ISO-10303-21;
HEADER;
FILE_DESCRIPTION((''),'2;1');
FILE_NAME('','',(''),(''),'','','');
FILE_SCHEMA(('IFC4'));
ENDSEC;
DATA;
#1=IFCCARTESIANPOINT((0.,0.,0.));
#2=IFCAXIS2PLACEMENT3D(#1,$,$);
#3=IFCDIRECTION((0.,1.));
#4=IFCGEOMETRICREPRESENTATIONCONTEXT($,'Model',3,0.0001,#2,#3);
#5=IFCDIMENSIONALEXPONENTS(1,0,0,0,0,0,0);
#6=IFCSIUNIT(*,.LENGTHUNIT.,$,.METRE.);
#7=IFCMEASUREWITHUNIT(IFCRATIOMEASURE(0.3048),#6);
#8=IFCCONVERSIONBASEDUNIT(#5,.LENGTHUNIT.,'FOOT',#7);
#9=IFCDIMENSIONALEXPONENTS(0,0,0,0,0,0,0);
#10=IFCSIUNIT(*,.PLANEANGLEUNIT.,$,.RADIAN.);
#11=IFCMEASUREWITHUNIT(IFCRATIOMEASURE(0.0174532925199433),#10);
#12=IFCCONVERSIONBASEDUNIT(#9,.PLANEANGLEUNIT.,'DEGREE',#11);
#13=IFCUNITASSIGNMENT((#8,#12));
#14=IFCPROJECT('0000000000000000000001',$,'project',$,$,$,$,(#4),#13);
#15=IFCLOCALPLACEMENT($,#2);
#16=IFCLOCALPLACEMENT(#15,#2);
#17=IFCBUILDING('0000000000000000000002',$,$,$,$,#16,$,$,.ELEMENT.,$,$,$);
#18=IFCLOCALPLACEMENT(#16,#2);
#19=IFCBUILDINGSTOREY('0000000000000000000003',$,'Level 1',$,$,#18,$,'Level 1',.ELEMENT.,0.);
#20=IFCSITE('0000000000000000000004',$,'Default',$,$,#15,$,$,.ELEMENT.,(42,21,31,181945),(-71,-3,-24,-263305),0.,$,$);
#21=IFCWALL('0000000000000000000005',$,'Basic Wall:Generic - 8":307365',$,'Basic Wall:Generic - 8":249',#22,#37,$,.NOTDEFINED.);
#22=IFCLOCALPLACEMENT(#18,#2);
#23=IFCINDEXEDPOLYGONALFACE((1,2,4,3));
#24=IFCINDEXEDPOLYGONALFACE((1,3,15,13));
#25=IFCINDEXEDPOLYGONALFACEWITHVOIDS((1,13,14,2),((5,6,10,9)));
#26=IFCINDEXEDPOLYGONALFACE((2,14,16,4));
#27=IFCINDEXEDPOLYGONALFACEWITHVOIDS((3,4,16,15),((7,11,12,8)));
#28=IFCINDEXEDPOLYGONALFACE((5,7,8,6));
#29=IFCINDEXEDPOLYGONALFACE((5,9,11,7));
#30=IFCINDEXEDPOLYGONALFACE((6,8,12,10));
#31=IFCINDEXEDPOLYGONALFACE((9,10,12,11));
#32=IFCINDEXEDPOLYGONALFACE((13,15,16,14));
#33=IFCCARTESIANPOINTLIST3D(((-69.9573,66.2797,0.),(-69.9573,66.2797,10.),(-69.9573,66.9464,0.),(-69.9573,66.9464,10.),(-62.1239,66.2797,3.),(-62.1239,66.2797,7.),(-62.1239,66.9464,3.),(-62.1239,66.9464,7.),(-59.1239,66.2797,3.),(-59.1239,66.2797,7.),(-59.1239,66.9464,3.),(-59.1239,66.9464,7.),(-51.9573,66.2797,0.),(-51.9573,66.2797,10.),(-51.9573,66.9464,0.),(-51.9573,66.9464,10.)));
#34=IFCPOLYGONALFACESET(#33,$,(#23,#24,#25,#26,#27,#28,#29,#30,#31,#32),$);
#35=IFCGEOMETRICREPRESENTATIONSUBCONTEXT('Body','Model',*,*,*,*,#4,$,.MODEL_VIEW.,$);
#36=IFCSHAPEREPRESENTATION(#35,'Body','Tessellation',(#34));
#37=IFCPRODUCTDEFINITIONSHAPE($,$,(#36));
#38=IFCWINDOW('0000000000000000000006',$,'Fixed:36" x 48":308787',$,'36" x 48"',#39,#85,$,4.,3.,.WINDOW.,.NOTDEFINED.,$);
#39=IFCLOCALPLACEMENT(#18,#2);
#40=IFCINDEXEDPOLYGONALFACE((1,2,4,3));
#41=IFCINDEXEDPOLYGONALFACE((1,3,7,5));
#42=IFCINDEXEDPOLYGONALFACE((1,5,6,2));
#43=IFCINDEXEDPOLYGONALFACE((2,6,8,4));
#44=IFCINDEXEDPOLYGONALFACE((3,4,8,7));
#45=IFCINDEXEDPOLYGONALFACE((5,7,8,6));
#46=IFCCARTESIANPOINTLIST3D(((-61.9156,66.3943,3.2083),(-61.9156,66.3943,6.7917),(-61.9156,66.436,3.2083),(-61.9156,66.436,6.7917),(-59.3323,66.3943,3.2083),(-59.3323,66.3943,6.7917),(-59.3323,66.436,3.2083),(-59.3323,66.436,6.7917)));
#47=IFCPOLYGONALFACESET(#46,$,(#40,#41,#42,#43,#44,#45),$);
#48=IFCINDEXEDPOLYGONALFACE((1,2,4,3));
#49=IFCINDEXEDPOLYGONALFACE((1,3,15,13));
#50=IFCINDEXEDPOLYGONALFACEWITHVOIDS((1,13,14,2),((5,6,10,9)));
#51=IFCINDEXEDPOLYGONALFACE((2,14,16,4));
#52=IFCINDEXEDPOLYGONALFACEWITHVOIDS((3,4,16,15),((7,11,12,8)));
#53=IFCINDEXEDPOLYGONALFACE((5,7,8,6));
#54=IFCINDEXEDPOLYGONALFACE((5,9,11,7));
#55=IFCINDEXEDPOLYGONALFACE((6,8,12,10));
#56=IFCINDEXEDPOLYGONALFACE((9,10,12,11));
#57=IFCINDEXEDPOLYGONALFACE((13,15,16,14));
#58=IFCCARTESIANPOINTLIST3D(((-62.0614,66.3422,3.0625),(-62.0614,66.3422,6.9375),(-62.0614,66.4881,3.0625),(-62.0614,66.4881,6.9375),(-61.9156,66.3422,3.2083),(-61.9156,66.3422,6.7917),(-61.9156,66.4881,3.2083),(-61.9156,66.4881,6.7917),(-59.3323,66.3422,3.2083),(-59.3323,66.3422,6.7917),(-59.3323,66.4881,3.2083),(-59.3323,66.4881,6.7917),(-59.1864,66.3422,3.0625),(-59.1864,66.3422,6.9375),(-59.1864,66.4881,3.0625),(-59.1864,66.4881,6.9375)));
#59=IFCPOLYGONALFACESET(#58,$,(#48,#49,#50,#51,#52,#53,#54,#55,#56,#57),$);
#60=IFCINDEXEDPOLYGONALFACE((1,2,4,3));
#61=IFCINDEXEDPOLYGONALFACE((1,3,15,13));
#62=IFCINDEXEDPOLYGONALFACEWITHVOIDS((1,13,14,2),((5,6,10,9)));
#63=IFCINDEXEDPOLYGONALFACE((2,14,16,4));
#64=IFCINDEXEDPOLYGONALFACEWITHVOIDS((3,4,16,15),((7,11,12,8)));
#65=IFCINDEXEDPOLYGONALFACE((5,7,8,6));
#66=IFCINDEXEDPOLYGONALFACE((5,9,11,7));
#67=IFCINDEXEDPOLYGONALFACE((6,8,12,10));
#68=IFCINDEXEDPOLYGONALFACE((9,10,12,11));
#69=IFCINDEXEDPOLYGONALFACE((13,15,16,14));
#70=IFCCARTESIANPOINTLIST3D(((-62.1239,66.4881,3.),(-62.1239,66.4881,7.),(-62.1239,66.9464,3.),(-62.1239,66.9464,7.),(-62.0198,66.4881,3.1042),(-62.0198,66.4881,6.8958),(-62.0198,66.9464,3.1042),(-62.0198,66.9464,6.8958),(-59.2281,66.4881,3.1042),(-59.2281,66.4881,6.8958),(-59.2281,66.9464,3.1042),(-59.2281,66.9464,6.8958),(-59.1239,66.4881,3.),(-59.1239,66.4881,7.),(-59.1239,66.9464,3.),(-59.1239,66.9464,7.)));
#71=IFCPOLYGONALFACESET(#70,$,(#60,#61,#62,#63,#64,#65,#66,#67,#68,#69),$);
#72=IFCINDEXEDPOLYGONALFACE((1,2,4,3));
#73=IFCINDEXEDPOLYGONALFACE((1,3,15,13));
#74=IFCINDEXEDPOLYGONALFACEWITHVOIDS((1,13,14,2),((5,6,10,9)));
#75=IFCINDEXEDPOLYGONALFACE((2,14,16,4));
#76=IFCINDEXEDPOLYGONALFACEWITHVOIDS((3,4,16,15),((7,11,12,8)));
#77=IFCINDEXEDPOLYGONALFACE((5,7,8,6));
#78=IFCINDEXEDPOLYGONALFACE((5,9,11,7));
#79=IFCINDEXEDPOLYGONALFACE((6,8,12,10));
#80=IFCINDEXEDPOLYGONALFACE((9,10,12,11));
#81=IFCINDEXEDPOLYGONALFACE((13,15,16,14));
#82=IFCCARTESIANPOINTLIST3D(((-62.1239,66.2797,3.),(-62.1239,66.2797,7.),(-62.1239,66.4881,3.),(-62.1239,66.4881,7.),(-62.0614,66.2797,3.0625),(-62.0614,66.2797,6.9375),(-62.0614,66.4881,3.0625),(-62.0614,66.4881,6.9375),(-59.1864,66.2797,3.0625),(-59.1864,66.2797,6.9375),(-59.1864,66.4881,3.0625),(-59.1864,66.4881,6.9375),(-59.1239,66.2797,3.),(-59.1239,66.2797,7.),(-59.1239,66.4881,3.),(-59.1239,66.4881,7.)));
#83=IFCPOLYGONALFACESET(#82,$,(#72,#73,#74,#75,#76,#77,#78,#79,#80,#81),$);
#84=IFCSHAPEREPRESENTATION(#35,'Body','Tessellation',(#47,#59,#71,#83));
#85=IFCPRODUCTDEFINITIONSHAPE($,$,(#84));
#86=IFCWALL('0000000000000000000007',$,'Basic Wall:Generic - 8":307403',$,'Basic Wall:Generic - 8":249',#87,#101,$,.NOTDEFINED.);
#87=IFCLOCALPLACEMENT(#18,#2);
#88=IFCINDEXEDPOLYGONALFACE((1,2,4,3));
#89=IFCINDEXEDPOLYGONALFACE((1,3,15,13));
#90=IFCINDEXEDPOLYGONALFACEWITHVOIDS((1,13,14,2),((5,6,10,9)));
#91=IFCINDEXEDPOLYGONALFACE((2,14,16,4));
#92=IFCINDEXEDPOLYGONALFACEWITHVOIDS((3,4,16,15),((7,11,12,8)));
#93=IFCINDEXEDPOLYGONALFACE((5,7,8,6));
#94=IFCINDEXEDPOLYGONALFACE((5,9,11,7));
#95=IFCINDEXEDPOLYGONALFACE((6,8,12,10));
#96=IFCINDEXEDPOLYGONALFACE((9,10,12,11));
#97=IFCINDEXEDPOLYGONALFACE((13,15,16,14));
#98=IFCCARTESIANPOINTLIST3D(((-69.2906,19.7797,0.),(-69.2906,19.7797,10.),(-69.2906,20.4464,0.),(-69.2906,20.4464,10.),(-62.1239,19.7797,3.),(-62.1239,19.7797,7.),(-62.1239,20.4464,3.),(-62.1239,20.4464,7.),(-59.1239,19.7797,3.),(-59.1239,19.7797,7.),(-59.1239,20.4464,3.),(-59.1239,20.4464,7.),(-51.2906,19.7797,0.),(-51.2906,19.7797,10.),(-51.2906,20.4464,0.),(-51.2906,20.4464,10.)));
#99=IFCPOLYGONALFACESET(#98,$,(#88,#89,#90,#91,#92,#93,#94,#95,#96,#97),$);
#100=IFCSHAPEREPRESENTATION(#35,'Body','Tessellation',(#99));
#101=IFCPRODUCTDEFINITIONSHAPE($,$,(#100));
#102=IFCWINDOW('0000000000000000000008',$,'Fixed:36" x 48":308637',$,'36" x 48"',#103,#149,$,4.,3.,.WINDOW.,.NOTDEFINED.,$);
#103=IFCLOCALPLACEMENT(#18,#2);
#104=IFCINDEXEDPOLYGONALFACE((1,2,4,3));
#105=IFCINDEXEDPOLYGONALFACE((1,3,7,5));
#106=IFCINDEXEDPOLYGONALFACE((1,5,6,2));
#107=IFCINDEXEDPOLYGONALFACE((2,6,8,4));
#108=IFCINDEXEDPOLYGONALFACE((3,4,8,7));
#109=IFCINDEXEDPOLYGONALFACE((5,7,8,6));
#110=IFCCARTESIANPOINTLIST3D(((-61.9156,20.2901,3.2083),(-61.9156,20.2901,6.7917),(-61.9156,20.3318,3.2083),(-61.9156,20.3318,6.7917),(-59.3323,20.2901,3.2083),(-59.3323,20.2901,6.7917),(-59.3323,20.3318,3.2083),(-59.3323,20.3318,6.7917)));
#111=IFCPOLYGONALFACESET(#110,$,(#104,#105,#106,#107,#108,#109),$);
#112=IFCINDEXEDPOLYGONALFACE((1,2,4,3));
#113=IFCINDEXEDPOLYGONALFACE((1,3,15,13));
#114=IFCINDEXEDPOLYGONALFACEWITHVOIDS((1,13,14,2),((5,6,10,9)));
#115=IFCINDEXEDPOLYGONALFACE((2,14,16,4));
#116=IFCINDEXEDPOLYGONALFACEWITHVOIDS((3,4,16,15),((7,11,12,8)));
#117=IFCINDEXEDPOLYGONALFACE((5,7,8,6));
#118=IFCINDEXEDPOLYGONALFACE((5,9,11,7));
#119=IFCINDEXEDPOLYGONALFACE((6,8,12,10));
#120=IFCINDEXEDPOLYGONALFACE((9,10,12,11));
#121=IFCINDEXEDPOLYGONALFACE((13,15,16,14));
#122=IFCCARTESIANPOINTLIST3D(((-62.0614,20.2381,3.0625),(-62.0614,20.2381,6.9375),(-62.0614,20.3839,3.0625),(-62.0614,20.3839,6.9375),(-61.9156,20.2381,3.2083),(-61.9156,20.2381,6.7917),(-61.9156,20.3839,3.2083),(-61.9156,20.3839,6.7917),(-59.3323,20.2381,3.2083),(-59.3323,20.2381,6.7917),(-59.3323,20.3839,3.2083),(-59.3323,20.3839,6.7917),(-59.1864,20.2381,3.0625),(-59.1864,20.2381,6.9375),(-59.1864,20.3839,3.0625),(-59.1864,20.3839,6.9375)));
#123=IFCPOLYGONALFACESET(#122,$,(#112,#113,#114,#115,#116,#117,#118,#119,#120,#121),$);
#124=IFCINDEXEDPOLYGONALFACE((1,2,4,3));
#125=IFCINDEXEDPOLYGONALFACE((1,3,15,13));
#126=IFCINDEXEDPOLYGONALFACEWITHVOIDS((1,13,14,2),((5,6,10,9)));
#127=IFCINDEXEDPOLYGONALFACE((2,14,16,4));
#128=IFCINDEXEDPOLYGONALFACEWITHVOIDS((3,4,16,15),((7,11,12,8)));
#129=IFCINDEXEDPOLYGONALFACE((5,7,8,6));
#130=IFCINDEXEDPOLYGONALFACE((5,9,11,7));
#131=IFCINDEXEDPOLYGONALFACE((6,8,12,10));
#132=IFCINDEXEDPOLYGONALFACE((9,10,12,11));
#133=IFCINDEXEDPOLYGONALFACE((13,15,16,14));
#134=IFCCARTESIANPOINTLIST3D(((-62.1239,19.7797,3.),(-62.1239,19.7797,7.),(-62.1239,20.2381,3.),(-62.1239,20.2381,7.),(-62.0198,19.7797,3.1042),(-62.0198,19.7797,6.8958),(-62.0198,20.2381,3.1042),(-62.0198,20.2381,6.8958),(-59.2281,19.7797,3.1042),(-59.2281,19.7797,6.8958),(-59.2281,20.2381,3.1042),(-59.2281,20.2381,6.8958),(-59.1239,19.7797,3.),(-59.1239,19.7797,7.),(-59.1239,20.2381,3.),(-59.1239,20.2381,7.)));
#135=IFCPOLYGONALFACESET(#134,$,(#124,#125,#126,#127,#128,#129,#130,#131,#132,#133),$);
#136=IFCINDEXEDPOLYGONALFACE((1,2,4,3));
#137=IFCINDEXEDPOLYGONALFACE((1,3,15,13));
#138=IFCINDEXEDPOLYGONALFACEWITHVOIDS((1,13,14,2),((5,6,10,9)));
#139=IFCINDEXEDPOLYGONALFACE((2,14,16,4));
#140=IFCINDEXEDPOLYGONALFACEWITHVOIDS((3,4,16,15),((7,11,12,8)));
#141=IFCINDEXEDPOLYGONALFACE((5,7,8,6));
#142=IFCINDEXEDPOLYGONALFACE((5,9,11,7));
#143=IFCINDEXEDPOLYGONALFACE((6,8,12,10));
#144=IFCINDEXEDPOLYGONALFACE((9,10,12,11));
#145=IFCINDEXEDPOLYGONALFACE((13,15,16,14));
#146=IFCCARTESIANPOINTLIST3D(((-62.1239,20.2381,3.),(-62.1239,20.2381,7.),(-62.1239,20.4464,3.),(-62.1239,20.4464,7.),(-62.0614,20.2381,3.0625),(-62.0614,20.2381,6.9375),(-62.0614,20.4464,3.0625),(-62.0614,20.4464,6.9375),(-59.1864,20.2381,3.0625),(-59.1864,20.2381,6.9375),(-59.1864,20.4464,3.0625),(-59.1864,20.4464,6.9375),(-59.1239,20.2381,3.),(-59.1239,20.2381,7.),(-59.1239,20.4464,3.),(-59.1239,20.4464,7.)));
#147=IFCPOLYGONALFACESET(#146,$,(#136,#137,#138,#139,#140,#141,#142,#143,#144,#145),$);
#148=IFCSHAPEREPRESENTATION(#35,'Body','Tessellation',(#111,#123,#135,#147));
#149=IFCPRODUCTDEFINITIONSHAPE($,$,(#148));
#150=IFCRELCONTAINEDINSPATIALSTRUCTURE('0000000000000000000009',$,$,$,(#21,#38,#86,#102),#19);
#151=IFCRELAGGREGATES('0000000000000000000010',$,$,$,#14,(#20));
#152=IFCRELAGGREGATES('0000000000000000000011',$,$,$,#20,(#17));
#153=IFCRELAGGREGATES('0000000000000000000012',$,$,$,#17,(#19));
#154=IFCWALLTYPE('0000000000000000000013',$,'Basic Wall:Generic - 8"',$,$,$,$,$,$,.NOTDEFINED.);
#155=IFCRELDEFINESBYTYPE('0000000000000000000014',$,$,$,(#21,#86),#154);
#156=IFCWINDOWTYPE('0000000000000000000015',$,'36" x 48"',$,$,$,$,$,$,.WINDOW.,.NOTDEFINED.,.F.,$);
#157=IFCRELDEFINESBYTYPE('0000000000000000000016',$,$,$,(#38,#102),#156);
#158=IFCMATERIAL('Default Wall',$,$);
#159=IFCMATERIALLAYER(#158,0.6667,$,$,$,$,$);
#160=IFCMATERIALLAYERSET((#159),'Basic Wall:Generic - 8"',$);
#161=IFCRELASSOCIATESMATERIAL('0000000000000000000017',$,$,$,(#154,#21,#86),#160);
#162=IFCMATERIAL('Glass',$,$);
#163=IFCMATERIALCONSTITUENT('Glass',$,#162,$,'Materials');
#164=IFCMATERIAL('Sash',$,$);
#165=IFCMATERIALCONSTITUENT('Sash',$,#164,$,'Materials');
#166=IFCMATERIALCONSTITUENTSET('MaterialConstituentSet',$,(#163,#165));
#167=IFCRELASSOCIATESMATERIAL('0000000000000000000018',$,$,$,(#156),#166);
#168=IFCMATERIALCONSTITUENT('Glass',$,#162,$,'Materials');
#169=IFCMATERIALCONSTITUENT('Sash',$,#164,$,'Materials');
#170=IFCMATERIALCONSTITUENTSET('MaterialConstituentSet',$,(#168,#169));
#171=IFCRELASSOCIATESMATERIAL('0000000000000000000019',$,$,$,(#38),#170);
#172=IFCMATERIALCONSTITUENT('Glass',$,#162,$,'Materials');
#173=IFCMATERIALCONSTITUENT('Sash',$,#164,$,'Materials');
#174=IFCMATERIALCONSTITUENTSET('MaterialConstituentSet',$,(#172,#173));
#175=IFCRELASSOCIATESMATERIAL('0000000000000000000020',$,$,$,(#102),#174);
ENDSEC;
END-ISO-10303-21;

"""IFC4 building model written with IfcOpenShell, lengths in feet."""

from ifc_helpers import new_model, entity, si_unit, converted_unit, direction, frame, frame_2d, origin, place, context, subcontext, project, spatial, polyline, rectangle, outline, extrude, source, transform, mapped, material, layer, layer_set, layer_usage, constituent, constituent_set, type_object, type_shapes, element, fill, save


model = new_model("IFC4")

# Units and contexts
model_context = context("Model", 3, precision=0.0001, world=origin(), true_north=direction((0.0, 1.0)))
body_context = subcontext(model_context, "Body", "Model", "MODEL_VIEW")
ifc_project = project(units=[converted_unit("LENGTHUNIT", "FOOT", entity("IfcRatioMeasure", 0.3048), si_unit("LENGTHUNIT", "METRE"), dimensions=[1, 0, 0, 0, 0, 0, 0]), converted_unit("PLANEANGLEUNIT", "DEGREE", entity("IfcRatioMeasure", 0.0174532925199433), si_unit("PLANEANGLEUNIT", "RADIAN"), dimensions=[0, 0, 0, 0, 0, 0, 0])], contexts=[model_context])

# Site, building, storey
site_placement = place(None, origin())
site = spatial("IfcSite", under=ifc_project, at=site_placement, Name="Default", CompositionType="ELEMENT", RefLatitude=(42, 21, 31, 181945), RefLongitude=(-71, -3, -24, -263305), RefElevation=0.0)
building_placement = place(site_placement, origin())
building = spatial("IfcBuilding", under=site, at=building_placement, CompositionType="ELEMENT")
storey_placement = place(building_placement, origin())
storey = spatial("IfcBuildingStorey", under=building, at=storey_placement, Name="Level 1", LongName="Level 1", CompositionType="ELEMENT", Elevation=0.0)

# Wall, opening, window
ifc_material_1 = material(Name="Default Wall")
ifc_layer = layer(ifc_material_1, 0.6667)
ifc_layer_set = layer_set([ifc_layer], Name="Basic Wall:Generic - 8\"")
ifc_layer_usage_1 = layer_usage(ifc_layer_set, "AXIS2", "NEGATIVE", 0.3333)
wall_type = type_object("IfcWallType", Name="Basic Wall:Generic - 8\"", PredefinedType="NOTDEFINED", material=ifc_layer_set)
wall_1_placement = place(storey_placement, frame((-69.9573, 66.6131, 0.0)))
wall_1 = element("IfcWall", 1, at=wall_1_placement, inside=storey, type_object=wall_type, material=ifc_layer_usage_1, Name="Basic Wall:Generic - 8\":307365", ObjectType="Basic Wall:Generic - 8\":249", PredefinedType="NOTDEFINED", context=body_context, shape_type="SweptSolid", body=[
    extrude(rectangle(XDim=18.0, YDim=0.6667, at=frame_2d((9.0, 0.0), x_axis=(-1.0, 0.0))), origin(), (0.0, 0.0, 1.0), 10.0),
])
opening_1_placement = place(wall_1_placement, frame((10.8333, 0.3333, 3.0)))
opening_1 = element("IfcOpeningElement", 2, at=opening_1_placement, cuts=wall_1, ObjectType="Opening", PredefinedType="OPENING", context=body_context, shape_type="SweptSolid", body=[
    extrude(rectangle(XDim=4.0, YDim=3.0, at=frame_2d((2.0, 1.5), x_axis=(-1.0, 0.0))), frame((0.0, 0.0, 0.0), z_axis=(0.0, -1.0, 0.0), x_axis=(0.0, 0.0, 1.0)), (0.0, 0.0, 1.0), 0.6667),
])
ifc_material_2 = material(Name="Glass")
ifc_constituent_1 = constituent(ifc_material_2, Name="Glass", Category="Materials")
ifc_material_3 = material(Name="Sash")
ifc_constituent_2 = constituent(ifc_material_3, Name="Sash", Category="Materials")
ifc_constituent_set_1 = constituent_set(constituents=[ifc_constituent_1, ifc_constituent_2], Name="MaterialConstituentSet")
ifc_constituent_3 = constituent(ifc_material_2, Name="Glass", Category="Materials")
ifc_constituent_4 = constituent(ifc_material_3, Name="Sash", Category="Materials")
ifc_constituent_set_2 = constituent_set(constituents=[ifc_constituent_3, ifc_constituent_4], Name="MaterialConstituentSet")
window_type_1 = type_object("IfcWindowType", Name="36\" x 48\"", ParameterTakesPrecedence=False, PartitioningType="NOTDEFINED", PredefinedType="WINDOW", material=ifc_constituent_set_2)
shared_shape_1 = source(origin(), body_context, "Body", "SweptSolid", [
    extrude(rectangle(XDim=0.0417, YDim=2.5833, at=frame_2d((0.0, 0.0), x_axis=(1.0, 0.0))), frame((1.5, 0.5312, 0.2083), z_axis=(0.0, 0.0, 1.0), x_axis=(0.0, 1.0, 0.0)), (0.0, 0.0, 1.0), 3.5833),
    extrude(outline(polyline([(-1.4375, -1.9375), (1.4375, -1.9375), (1.4375, 1.9375), (-1.4375, 1.9375), (-1.4375, -1.9375)]), holes=[polyline([(-1.2917, -1.7917), (-1.2917, 1.7917), (1.2917, 1.7917), (1.2917, -1.7917), (-1.2917, -1.7917)])]), frame((1.5, 0.4583, 2.0), z_axis=(0.0, 1.0, 0.0), x_axis=(1.0, 0.0, 0.0)), (0.0, 0.0, 1.0), 0.1458),
    extrude(outline(polyline([(-1.5, -2.0), (1.5, -2.0), (1.5, 2.0), (-1.5, 2.0), (-1.5, -2.0)]), holes=[polyline([(-1.3958, -1.8958), (-1.3958, 1.8958), (1.3958, 1.8958), (1.3958, -1.8958), (-1.3958, -1.8958)])]), frame((1.5, 0.0, 2.0), z_axis=(0.0, 1.0, 0.0), x_axis=(1.0, 0.0, 0.0)), (0.0, 0.0, 1.0), 0.4583),
    extrude(outline(polyline([(-2.0, -1.5), (2.0, -1.5), (2.0, 1.5), (-2.0, 1.5), (-2.0, -1.5)]), holes=[polyline([(-1.9375, -1.4375), (-1.9375, 1.4375), (1.9375, 1.4375), (1.9375, -1.4375), (-1.9375, -1.4375)])]), frame((1.5, 0.4583, 2.0), z_axis=(0.0, 1.0, 0.0), x_axis=(0.0, 0.0, -1.0)), (0.0, 0.0, 1.0), 0.2083),
])
type_shapes(window_type_1, [shared_shape_1])
window_1_placement = place(opening_1_placement, frame((0.0, 0.0, 0.0), z_axis=(0.0, 0.0, 1.0), x_axis=(-1.0, 0.0, 0.0)))
window_1 = element("IfcWindow", 3, at=window_1_placement, inside=storey, type_object=window_type_1, material=ifc_constituent_set_1, Name="Fixed:36\" x 48\":308787", ObjectType="36\" x 48\"", OverallHeight=4.0, OverallWidth=3.0, PartitioningType="NOTDEFINED", PredefinedType="WINDOW", context=body_context, shape_type="MappedRepresentation", body=[
    mapped(shared_shape_1, transform((0.0, 0.0, 0.0), scale=1.0)),
])
fill(opening_1, window_1)

# Wall, opening, window
ifc_layer_usage_2 = layer_usage(ifc_layer_set, "AXIS2", "NEGATIVE", 0.3333)
wall_2_placement = place(storey_placement, frame((-69.2906, 20.1131, 0.0)))
wall_2 = element("IfcWall", 4, at=wall_2_placement, inside=storey, type_object=wall_type, material=ifc_layer_usage_2, Name="Basic Wall:Generic - 8\":307403", ObjectType="Basic Wall:Generic - 8\":249", PredefinedType="NOTDEFINED", context=body_context, shape_type="SweptSolid", body=[
    extrude(rectangle(XDim=18.0, YDim=0.6667, at=frame_2d((9.0, 0.0), x_axis=(-1.0, 0.0))), origin(), (0.0, 0.0, 1.0), 10.0),
])
opening_2_placement = place(wall_2_placement, frame((7.1667, -0.3333, 3.0)))
opening_2 = element("IfcOpeningElement", 5, at=opening_2_placement, cuts=wall_2, ObjectType="Opening", PredefinedType="OPENING", context=body_context, shape_type="SweptSolid", body=[
    extrude(rectangle(XDim=4.0, YDim=3.0, at=frame_2d((2.0, 1.5), x_axis=(-1.0, 0.0))), frame((0.0, 0.0, 0.0), z_axis=(0.0, 1.0, 0.0), x_axis=(0.0, 0.0, 1.0)), (0.0, 0.0, 1.0), 0.6667),
])
ifc_constituent_5 = constituent(ifc_material_2, Name="Glass", Category="Materials")
ifc_constituent_6 = constituent(ifc_material_3, Name="Sash", Category="Materials")
ifc_constituent_set_3 = constituent_set(constituents=[ifc_constituent_5, ifc_constituent_6], Name="MaterialConstituentSet")
window_2_placement = place(opening_2_placement, origin())
window_2 = element("IfcWindow", 6, at=window_2_placement, inside=storey, type_object=window_type_1, material=ifc_constituent_set_3, Name="Fixed:36\" x 48\":308637", ObjectType="36\" x 48\"", OverallHeight=4.0, OverallWidth=3.0, PartitioningType="NOTDEFINED", PredefinedType="WINDOW", context=body_context, shape_type="MappedRepresentation", body=[
    mapped(shared_shape_1, transform((0.0, 0.0, 0.0), scale=1.0)),
])
fill(opening_2, window_2)

save(model, "model.ifc")
